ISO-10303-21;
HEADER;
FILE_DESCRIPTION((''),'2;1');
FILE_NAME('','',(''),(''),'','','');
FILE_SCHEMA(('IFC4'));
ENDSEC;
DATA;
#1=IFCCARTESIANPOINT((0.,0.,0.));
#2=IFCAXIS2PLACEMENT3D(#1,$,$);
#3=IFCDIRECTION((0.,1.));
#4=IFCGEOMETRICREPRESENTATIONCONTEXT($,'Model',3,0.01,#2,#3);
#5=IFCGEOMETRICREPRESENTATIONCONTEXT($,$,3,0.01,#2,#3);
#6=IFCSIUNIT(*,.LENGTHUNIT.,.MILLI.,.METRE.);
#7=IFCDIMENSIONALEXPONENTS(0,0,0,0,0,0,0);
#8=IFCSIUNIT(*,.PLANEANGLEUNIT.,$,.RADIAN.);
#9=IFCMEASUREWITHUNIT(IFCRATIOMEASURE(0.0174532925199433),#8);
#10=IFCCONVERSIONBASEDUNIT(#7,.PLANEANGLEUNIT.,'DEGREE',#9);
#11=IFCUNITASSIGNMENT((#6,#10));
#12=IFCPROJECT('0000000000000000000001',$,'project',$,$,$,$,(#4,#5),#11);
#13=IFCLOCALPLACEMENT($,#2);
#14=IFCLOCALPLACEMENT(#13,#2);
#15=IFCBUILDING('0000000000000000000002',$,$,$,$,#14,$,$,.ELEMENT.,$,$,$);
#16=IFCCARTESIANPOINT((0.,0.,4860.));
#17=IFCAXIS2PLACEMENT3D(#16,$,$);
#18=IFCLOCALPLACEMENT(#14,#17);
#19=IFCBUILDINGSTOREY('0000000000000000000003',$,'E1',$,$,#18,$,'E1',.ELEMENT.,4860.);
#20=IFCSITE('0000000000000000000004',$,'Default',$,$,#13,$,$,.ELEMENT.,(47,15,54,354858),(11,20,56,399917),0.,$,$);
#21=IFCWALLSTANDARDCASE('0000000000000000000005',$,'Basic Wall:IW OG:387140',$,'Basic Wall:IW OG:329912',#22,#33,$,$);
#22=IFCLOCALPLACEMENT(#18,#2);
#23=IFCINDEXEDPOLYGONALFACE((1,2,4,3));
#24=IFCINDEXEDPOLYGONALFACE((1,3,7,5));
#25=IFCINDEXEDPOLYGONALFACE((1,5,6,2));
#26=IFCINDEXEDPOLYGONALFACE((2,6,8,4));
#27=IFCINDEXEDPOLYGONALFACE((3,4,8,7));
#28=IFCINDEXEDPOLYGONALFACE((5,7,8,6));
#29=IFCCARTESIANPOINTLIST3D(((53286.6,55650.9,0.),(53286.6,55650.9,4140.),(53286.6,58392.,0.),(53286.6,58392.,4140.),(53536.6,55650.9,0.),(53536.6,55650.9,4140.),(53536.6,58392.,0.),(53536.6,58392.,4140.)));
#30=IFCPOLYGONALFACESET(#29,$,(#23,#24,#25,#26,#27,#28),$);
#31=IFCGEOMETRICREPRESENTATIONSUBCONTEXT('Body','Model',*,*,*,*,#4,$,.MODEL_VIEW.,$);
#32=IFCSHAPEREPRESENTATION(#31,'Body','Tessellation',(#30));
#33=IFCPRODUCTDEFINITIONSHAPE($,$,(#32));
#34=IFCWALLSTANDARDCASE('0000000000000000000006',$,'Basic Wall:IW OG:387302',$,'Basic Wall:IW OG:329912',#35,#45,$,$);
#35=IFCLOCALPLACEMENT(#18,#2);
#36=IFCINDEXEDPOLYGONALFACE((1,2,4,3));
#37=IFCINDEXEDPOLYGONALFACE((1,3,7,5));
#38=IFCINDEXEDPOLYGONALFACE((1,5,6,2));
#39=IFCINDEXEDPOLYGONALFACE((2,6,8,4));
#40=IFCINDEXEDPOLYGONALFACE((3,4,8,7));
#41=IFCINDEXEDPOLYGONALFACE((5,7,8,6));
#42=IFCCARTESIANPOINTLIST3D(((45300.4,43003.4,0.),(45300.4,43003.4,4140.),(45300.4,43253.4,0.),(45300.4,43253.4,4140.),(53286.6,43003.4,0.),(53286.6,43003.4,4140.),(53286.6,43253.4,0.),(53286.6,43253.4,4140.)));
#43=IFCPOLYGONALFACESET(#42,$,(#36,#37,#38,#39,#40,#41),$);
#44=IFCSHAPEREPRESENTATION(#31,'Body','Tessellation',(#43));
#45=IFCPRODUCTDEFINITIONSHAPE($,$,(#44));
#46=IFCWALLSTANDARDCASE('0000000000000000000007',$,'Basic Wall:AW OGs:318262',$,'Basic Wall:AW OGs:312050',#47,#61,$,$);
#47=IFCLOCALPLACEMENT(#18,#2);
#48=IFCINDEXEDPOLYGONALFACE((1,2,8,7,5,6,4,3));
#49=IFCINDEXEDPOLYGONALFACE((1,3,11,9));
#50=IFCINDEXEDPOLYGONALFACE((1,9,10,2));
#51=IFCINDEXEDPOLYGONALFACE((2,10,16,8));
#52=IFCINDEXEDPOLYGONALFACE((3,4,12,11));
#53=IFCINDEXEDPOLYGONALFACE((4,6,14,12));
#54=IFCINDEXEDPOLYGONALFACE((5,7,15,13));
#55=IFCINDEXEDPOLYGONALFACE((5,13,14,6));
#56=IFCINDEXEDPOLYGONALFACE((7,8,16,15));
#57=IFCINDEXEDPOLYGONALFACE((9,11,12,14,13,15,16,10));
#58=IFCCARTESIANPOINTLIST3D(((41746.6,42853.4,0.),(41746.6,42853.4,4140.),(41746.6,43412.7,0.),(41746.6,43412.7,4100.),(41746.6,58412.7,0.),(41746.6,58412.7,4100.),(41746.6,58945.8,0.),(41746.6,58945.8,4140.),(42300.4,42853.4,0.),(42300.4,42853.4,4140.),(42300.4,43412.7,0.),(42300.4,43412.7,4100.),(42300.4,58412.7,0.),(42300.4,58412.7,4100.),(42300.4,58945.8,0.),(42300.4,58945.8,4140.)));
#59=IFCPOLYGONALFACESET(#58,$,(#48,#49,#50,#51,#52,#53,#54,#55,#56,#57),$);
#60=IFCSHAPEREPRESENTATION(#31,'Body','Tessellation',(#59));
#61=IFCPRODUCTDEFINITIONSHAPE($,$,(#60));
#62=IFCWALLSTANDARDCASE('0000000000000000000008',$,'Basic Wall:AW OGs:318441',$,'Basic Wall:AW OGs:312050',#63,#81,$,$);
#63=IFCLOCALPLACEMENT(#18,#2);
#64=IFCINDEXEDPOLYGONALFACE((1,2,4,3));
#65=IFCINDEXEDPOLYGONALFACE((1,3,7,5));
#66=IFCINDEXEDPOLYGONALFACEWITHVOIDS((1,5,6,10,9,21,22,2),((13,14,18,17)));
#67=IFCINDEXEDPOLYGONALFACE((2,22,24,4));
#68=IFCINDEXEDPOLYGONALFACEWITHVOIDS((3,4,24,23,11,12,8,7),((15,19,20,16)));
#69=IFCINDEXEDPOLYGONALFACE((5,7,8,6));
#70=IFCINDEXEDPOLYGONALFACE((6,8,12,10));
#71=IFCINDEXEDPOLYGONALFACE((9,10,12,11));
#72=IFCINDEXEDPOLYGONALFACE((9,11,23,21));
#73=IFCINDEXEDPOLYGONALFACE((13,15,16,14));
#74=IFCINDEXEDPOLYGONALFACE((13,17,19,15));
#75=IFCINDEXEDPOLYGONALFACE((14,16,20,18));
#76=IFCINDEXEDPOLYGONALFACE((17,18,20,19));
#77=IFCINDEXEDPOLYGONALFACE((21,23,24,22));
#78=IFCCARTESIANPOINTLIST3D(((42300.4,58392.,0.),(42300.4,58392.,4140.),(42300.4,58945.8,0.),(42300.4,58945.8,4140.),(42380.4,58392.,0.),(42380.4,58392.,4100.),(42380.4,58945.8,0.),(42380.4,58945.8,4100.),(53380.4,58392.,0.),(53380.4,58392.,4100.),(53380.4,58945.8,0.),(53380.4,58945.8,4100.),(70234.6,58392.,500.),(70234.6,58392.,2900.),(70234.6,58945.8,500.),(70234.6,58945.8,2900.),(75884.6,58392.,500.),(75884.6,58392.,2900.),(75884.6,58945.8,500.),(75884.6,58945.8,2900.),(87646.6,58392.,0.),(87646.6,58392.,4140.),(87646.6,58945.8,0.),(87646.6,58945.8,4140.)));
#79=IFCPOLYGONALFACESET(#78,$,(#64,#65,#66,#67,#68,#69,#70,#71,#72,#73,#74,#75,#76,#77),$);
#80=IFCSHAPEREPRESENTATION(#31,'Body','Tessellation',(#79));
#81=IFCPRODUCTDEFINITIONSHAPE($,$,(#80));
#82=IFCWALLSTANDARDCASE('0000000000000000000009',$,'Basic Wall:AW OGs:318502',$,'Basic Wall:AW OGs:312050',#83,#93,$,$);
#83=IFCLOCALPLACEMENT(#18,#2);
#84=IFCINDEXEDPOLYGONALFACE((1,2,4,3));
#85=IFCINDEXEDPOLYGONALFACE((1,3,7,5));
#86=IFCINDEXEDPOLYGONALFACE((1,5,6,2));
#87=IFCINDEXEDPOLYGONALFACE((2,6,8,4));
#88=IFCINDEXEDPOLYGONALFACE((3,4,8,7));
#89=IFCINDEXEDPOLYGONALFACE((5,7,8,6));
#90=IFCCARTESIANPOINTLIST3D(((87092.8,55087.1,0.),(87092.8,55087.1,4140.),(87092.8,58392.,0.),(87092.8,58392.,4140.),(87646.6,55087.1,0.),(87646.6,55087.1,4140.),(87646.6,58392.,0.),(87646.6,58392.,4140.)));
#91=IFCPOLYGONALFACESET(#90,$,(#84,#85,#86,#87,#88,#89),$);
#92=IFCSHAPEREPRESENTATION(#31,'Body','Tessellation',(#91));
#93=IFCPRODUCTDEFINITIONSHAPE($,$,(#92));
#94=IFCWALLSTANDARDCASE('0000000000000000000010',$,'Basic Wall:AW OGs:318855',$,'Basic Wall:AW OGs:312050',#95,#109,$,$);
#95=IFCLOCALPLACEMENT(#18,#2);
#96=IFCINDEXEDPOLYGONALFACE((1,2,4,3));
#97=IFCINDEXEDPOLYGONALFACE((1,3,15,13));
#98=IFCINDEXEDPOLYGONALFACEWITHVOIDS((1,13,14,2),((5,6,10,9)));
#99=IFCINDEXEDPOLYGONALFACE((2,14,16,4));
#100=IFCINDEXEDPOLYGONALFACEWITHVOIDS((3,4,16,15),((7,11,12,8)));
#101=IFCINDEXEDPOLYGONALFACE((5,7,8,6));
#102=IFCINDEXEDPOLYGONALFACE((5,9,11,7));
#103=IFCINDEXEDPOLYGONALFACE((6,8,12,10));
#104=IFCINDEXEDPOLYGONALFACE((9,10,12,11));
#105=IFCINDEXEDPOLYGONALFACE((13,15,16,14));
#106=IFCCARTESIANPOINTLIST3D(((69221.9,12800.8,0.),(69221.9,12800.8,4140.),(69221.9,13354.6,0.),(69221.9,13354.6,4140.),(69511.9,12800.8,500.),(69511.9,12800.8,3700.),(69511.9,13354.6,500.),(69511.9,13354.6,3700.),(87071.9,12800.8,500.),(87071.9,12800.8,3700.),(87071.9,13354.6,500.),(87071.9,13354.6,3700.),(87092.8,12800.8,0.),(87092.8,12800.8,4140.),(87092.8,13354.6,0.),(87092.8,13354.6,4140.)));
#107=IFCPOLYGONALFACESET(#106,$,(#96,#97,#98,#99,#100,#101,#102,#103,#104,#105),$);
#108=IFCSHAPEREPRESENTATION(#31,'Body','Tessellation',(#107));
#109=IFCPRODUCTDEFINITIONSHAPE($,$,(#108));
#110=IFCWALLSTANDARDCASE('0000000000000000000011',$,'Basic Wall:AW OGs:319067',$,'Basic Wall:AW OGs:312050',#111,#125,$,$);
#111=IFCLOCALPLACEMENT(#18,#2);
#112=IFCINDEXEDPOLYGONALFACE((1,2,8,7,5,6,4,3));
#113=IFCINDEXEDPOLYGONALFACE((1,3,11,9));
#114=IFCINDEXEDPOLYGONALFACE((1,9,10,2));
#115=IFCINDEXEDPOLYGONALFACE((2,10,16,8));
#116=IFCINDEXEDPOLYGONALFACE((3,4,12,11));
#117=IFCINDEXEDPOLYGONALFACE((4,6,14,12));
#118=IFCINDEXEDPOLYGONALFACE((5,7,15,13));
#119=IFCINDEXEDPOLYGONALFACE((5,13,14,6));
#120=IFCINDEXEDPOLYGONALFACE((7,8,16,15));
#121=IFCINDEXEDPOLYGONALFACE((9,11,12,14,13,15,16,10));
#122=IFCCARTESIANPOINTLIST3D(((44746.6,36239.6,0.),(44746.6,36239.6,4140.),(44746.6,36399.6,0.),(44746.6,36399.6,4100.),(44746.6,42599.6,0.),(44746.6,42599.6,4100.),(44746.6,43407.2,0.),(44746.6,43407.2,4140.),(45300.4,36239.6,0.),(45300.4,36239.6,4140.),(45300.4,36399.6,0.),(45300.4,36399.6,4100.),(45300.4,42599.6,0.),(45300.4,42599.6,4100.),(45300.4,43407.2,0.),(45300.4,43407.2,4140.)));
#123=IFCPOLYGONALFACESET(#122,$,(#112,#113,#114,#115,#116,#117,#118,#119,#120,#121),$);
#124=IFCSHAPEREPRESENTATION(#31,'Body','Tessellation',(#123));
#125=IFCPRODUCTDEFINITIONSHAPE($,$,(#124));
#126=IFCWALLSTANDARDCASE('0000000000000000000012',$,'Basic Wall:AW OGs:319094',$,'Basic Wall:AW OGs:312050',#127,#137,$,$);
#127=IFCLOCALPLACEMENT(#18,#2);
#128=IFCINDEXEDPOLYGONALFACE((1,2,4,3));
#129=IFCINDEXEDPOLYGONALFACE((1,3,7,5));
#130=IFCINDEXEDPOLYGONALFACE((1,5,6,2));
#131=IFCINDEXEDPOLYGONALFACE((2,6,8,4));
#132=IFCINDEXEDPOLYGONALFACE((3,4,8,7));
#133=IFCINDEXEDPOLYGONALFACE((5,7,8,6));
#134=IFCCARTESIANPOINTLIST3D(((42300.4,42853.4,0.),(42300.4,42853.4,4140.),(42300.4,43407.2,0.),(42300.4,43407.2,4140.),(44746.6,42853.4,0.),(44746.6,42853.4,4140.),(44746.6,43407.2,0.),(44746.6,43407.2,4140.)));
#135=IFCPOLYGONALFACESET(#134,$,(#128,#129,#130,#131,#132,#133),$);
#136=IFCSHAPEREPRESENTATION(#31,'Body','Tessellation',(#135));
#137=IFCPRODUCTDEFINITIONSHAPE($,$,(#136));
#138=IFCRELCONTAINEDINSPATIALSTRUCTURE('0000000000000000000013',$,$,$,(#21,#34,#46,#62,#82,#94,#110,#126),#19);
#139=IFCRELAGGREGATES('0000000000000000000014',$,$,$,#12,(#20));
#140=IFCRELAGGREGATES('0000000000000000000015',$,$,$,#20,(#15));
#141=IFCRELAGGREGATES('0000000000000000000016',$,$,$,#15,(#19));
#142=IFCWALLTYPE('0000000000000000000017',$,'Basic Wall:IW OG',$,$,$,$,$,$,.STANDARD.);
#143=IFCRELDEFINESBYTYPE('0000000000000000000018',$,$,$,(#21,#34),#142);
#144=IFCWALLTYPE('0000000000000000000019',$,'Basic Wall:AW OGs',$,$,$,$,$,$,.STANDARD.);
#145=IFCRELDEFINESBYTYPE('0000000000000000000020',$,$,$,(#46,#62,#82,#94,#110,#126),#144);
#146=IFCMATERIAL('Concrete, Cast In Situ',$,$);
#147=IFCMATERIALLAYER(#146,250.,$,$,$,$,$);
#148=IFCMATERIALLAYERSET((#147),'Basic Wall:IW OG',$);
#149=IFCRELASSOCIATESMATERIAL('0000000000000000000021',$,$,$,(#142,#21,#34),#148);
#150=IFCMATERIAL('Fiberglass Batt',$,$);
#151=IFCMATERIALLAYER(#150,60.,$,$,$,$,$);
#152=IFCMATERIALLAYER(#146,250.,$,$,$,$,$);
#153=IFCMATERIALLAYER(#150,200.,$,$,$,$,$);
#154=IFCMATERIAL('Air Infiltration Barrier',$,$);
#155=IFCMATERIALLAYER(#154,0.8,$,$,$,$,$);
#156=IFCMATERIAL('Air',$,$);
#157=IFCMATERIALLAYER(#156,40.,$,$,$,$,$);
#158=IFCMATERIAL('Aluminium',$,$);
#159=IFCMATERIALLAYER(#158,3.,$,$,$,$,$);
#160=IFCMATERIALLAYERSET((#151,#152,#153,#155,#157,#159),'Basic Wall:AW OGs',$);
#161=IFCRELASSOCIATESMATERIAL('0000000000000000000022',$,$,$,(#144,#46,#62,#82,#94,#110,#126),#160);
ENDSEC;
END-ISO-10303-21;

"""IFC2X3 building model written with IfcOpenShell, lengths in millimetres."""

from ifc_helpers import new_model, entity, si_unit, converted_unit, direction, frame, frame_2d, origin, place, context, subcontext, project, spatial, rectangle, extrude, material, layer, layer_set, layer_usage, type_object, element, save


model = new_model("IFC2X3")

# Units and contexts
model_context = context("Model", 3, precision=0.01, world=origin(), true_north=direction((0.0, 1.0)))
context_of_model = context(None, 3, precision=0.01, world=origin(), true_north=direction((0.0, 1.0)))
body_context = subcontext(model_context, "Body", "Model", "MODEL_VIEW")
ifc_project = project(units=[si_unit("LENGTHUNIT", "METRE", prefix="MILLI"), converted_unit("PLANEANGLEUNIT", "DEGREE", entity("IfcRatioMeasure", 0.0174532925199433), si_unit("PLANEANGLEUNIT", "RADIAN"), dimensions=[0, 0, 0, 0, 0, 0, 0])], contexts=[model_context, context_of_model])

# Site, building, storey
site_placement = place(None, origin())
site = spatial("IfcSite", under=ifc_project, at=site_placement, Name="Default", CompositionType="ELEMENT", RefLatitude=(47, 15, 54, 354858), RefLongitude=(11, 20, 56, 399917), RefElevation=0.0)
building_placement = place(site_placement, origin())
building = spatial("IfcBuilding", under=site, at=building_placement, CompositionType="ELEMENT")
storey_placement = place(building_placement, frame((0.0, 0.0, 4860.0)))
storey = spatial("IfcBuildingStorey", under=building, at=storey_placement, Name="E1", LongName="E1", CompositionType="ELEMENT", Elevation=4860.0)

# Shared definitions
ifc_material_1 = material(Name="Air Infiltration Barrier")
ifc_material_2 = material(Name="Fiberglass Batt")

# Shared definitions
ifc_material_3 = material(Name="Aluminium")

# Walls
ifc_material_4 = material(Name="Concrete, Cast In Situ")
ifc_layer_1 = layer(ifc_material_4, 250.0)
ifc_layer_set_1 = layer_set([ifc_layer_1], Name="Basic Wall:IW OG")
ifc_layer_usage_1 = layer_usage(ifc_layer_set_1, "AXIS2", "NEGATIVE", 125.0)
wall_type_1 = type_object("IfcWallType", Name="Basic Wall:IW OG", PredefinedType="STANDARD", material=ifc_layer_set_1)
wall_1_placement = place(storey_placement, frame((53411.6, 55650.9, 0.0), z_axis=(0.0, 0.0, 1.0), x_axis=(0.0, 1.0, 0.0)))
element("IfcWallStandardCase", 1, at=wall_1_placement, inside=storey, type_object=wall_type_1, material=ifc_layer_usage_1, Name="Basic Wall:IW OG:387140", ObjectType="Basic Wall:IW OG:329912", context=body_context, shape_type="SweptSolid", body=[
    extrude(rectangle(XDim=2741.2, YDim=250.0, at=frame_2d((1370.6, 0.0), x_axis=(-1.0, 0.0))), origin(), (0.0, 0.0, 1.0), 4140.0),
])
ifc_layer_usage_2 = layer_usage(ifc_layer_set_1, "AXIS2", "NEGATIVE", 125.0)
wall_2_placement = place(storey_placement, frame((53286.6, 43128.4, 0.0), z_axis=(0.0, 0.0, 1.0), x_axis=(-1.0, 0.0, 0.0)))
element("IfcWallStandardCase", 2, at=wall_2_placement, inside=storey, type_object=wall_type_1, material=ifc_layer_usage_2, Name="Basic Wall:IW OG:387302", ObjectType="Basic Wall:IW OG:329912", context=body_context, shape_type="SweptSolid", body=[
    extrude(rectangle(XDim=7986.2, YDim=250.0, at=frame_2d((3993.1, 0.0), x_axis=(-1.0, 0.0))), origin(), (0.0, 0.0, 1.0), 4140.0),
])

# Wall, opening
ifc_layer_2 = layer(ifc_material_2, 60.0)
ifc_layer_3 = layer(ifc_material_4, 250.0)
ifc_layer_4 = layer(ifc_material_2, 200.0)
ifc_layer_5 = layer(ifc_material_1, 0.8)
ifc_material_5 = material(Name="Air")
ifc_layer_6 = layer(ifc_material_5, 40.0)
ifc_layer_7 = layer(ifc_material_3, 3.0)
ifc_layer_set_2 = layer_set([ifc_layer_2, ifc_layer_3, ifc_layer_4, ifc_layer_5, ifc_layer_6, ifc_layer_7], Name="Basic Wall:AW OGs")
ifc_layer_usage_3 = layer_usage(ifc_layer_set_2, "AXIS2", "POSITIVE", -276.9)
wall_type_2 = type_object("IfcWallType", Name="Basic Wall:AW OGs", PredefinedType="STANDARD", material=ifc_layer_set_2)
wall_3_placement = place(storey_placement, frame((42023.5, 42853.4, 0.0), z_axis=(0.0, 0.0, 1.0), x_axis=(0.0, 1.0, 0.0)))
wall_3 = element("IfcWallStandardCase", 3, at=wall_3_placement, inside=storey, type_object=wall_type_2, material=ifc_layer_usage_3, Name="Basic Wall:AW OGs:318262", ObjectType="Basic Wall:AW OGs:312050", context=body_context, shape_type="SweptSolid", body=[
    extrude(rectangle(XDim=16092.4, YDim=553.8, at=frame_2d((8046.2, 0.0), x_axis=(-1.0, 0.0))), origin(), (0.0, 0.0, 1.0), 4140.0),
])
opening_1_placement = place(wall_3_placement, frame((559.3, -276.9, 0.0)))
element("IfcOpeningElement", 4, at=opening_1_placement, cuts=wall_3, ObjectType="Opening", context=body_context, shape_type="SweptSolid", body=[
    extrude(rectangle(XDim=4100.0, YDim=15000.0, at=frame_2d((2050.0, 7500.0), x_axis=(-1.0, 0.0))), frame((0.0, 0.0, 0.0), z_axis=(0.0, 1.0, 0.0), x_axis=(0.0, 0.0, 1.0)), (0.0, 0.0, 1.0), 553.8),
])

# Wall, openings
ifc_layer_usage_4 = layer_usage(ifc_layer_set_2, "AXIS2", "POSITIVE", -276.9)
wall_4_placement = place(storey_placement, frame((42300.4, 58668.9, 0.0)))
wall_4 = element("IfcWallStandardCase", 5, at=wall_4_placement, inside=storey, type_object=wall_type_2, material=ifc_layer_usage_4, Name="Basic Wall:AW OGs:318441", ObjectType="Basic Wall:AW OGs:312050", context=body_context, shape_type="SweptSolid", body=[
    extrude(rectangle(XDim=45346.2, YDim=553.8, at=frame_2d((22673.1, 0.0), x_axis=(-1.0, 0.0))), origin(), (0.0, 0.0, 1.0), 4140.0),
])
opening_2_placement = place(wall_4_placement, frame((80.0, -276.9, 0.0)))
element("IfcOpeningElement", 6, at=opening_2_placement, cuts=wall_4, ObjectType="Opening", context=body_context, shape_type="SweptSolid", body=[
    extrude(rectangle(XDim=4100.0, YDim=11000.0, at=frame_2d((2050.0, 5500.0), x_axis=(-1.0, 0.0))), frame((0.0, 0.0, 0.0), z_axis=(0.0, 1.0, 0.0), x_axis=(0.0, 0.0, 1.0)), (0.0, 0.0, 1.0), 553.8),
])
opening_3_placement = place(wall_4_placement, frame((27934.3, -276.9, 500.0)))
element("IfcOpeningElement", 7, at=opening_3_placement, cuts=wall_4, ObjectType="Opening", context=body_context, shape_type="SweptSolid", body=[
    extrude(rectangle(XDim=2400.0, YDim=5650.0, at=frame_2d((1200.0, 2825.0), x_axis=(-1.0, 0.0))), frame((0.0, 0.0, 0.0), z_axis=(0.0, 1.0, 0.0), x_axis=(0.0, 0.0, 1.0)), (0.0, 0.0, 1.0), 553.8),
])

# Wall
ifc_layer_usage_5 = layer_usage(ifc_layer_set_2, "AXIS2", "POSITIVE", -276.9)
wall_5_placement = place(storey_placement, frame((87369.7, 58392.0, 0.0), z_axis=(0.0, 0.0, 1.0), x_axis=(0.0, -1.0, 0.0)))
element("IfcWallStandardCase", 8, at=wall_5_placement, inside=storey, type_object=wall_type_2, material=ifc_layer_usage_5, Name="Basic Wall:AW OGs:318502", ObjectType="Basic Wall:AW OGs:312050", context=body_context, shape_type="SweptSolid", body=[
    extrude(rectangle(XDim=3304.9, YDim=553.8, at=frame_2d((1652.5, 0.0), x_axis=(-1.0, 0.0))), origin(), (0.0, 0.0, 1.0), 4140.0),
])

# Wall, openings
ifc_layer_usage_6 = layer_usage(ifc_layer_set_2, "AXIS2", "POSITIVE", -276.9)
wall_6_placement = place(storey_placement, frame((87092.8, 13077.7, 0.0), z_axis=(0.0, 0.0, 1.0), x_axis=(-1.0, 0.0, 0.0)))
wall_6 = element("IfcWallStandardCase", 9, at=wall_6_placement, inside=storey, type_object=wall_type_2, material=ifc_layer_usage_6, Name="Basic Wall:AW OGs:318855", ObjectType="Basic Wall:AW OGs:312050", context=body_context, shape_type="SweptSolid", body=[
    extrude(rectangle(XDim=17870.9, YDim=553.8, at=frame_2d((8935.4, 0.0), x_axis=(-1.0, 0.0))), origin(), (0.0, 0.0, 1.0), 4140.0),
])
opening_4_placement = place(wall_6_placement, origin())
element("IfcOpeningElement", 10, at=opening_4_placement, cuts=wall_6, ObjectType="Opening", context=body_context, shape_type="SweptSolid", body=[
    extrude(rectangle(XDim=3200.0, YDim=553.8, at=frame_2d((0.0, 0.0), x_axis=(0.0, 1.0))), frame((-276.9, -29831.9, 2100.0), z_axis=(0.0, 1.0, 0.0), x_axis=(-1.0, 0.0, 0.0)), (0.0, 0.0, 1.0), 29555.0),
])
opening_5_placement = place(wall_6_placement, frame((20.9, -276.9, 500.0)))
element("IfcOpeningElement", 11, at=opening_5_placement, cuts=wall_6, ObjectType="Opening", context=body_context, shape_type="SweptSolid", body=[
    extrude(rectangle(XDim=3200.0, YDim=17560.0, at=frame_2d((1600.0, 8780.0), x_axis=(-1.0, 0.0))), frame((0.0, 0.0, 0.0), z_axis=(0.0, 1.0, 0.0), x_axis=(0.0, 0.0, 1.0)), (0.0, 0.0, 1.0), 553.8),
])

# Wall, opening
ifc_layer_usage_7 = layer_usage(ifc_layer_set_2, "AXIS2", "POSITIVE", -276.9)
wall_7_placement = place(storey_placement, frame((45023.5, 36239.6, 0.0), z_axis=(0.0, 0.0, 1.0), x_axis=(0.0, 1.0, 0.0)))
wall_7 = element("IfcWallStandardCase", 12, at=wall_7_placement, inside=storey, type_object=wall_type_2, material=ifc_layer_usage_7, Name="Basic Wall:AW OGs:319067", ObjectType="Basic Wall:AW OGs:312050", context=body_context, shape_type="SweptSolid", body=[
    extrude(rectangle(XDim=7167.6, YDim=553.8, at=frame_2d((3583.8, 0.0), x_axis=(-1.0, 0.0))), origin(), (0.0, 0.0, 1.0), 4140.0),
])
opening_6_placement = place(wall_7_placement, frame((160.0, -276.9, 0.0)))
element("IfcOpeningElement", 13, at=opening_6_placement, cuts=wall_7, ObjectType="Opening", context=body_context, shape_type="SweptSolid", body=[
    extrude(rectangle(XDim=4100.0, YDim=6200.0, at=frame_2d((2050.0, 3100.0), x_axis=(-1.0, 0.0))), frame((0.0, 0.0, 0.0), z_axis=(0.0, 1.0, 0.0), x_axis=(0.0, 0.0, 1.0)), (0.0, 0.0, 1.0), 553.8),
])

# Wall
ifc_layer_usage_8 = layer_usage(ifc_layer_set_2, "AXIS2", "POSITIVE", -276.9)
wall_8_placement = place(storey_placement, frame((44746.6, 43130.3, 0.0), z_axis=(0.0, 0.0, 1.0), x_axis=(-1.0, 0.0, 0.0)))
element("IfcWallStandardCase", 14, at=wall_8_placement, inside=storey, type_object=wall_type_2, material=ifc_layer_usage_8, Name="Basic Wall:AW OGs:319094", ObjectType="Basic Wall:AW OGs:312050", context=body_context, shape_type="SweptSolid", body=[
    extrude(rectangle(XDim=2446.2, YDim=553.8, at=frame_2d((1223.1, 0.0), x_axis=(-1.0, 0.0))), origin(), (0.0, 0.0, 1.0), 4140.0),
])

save(model, "model.ifc")
